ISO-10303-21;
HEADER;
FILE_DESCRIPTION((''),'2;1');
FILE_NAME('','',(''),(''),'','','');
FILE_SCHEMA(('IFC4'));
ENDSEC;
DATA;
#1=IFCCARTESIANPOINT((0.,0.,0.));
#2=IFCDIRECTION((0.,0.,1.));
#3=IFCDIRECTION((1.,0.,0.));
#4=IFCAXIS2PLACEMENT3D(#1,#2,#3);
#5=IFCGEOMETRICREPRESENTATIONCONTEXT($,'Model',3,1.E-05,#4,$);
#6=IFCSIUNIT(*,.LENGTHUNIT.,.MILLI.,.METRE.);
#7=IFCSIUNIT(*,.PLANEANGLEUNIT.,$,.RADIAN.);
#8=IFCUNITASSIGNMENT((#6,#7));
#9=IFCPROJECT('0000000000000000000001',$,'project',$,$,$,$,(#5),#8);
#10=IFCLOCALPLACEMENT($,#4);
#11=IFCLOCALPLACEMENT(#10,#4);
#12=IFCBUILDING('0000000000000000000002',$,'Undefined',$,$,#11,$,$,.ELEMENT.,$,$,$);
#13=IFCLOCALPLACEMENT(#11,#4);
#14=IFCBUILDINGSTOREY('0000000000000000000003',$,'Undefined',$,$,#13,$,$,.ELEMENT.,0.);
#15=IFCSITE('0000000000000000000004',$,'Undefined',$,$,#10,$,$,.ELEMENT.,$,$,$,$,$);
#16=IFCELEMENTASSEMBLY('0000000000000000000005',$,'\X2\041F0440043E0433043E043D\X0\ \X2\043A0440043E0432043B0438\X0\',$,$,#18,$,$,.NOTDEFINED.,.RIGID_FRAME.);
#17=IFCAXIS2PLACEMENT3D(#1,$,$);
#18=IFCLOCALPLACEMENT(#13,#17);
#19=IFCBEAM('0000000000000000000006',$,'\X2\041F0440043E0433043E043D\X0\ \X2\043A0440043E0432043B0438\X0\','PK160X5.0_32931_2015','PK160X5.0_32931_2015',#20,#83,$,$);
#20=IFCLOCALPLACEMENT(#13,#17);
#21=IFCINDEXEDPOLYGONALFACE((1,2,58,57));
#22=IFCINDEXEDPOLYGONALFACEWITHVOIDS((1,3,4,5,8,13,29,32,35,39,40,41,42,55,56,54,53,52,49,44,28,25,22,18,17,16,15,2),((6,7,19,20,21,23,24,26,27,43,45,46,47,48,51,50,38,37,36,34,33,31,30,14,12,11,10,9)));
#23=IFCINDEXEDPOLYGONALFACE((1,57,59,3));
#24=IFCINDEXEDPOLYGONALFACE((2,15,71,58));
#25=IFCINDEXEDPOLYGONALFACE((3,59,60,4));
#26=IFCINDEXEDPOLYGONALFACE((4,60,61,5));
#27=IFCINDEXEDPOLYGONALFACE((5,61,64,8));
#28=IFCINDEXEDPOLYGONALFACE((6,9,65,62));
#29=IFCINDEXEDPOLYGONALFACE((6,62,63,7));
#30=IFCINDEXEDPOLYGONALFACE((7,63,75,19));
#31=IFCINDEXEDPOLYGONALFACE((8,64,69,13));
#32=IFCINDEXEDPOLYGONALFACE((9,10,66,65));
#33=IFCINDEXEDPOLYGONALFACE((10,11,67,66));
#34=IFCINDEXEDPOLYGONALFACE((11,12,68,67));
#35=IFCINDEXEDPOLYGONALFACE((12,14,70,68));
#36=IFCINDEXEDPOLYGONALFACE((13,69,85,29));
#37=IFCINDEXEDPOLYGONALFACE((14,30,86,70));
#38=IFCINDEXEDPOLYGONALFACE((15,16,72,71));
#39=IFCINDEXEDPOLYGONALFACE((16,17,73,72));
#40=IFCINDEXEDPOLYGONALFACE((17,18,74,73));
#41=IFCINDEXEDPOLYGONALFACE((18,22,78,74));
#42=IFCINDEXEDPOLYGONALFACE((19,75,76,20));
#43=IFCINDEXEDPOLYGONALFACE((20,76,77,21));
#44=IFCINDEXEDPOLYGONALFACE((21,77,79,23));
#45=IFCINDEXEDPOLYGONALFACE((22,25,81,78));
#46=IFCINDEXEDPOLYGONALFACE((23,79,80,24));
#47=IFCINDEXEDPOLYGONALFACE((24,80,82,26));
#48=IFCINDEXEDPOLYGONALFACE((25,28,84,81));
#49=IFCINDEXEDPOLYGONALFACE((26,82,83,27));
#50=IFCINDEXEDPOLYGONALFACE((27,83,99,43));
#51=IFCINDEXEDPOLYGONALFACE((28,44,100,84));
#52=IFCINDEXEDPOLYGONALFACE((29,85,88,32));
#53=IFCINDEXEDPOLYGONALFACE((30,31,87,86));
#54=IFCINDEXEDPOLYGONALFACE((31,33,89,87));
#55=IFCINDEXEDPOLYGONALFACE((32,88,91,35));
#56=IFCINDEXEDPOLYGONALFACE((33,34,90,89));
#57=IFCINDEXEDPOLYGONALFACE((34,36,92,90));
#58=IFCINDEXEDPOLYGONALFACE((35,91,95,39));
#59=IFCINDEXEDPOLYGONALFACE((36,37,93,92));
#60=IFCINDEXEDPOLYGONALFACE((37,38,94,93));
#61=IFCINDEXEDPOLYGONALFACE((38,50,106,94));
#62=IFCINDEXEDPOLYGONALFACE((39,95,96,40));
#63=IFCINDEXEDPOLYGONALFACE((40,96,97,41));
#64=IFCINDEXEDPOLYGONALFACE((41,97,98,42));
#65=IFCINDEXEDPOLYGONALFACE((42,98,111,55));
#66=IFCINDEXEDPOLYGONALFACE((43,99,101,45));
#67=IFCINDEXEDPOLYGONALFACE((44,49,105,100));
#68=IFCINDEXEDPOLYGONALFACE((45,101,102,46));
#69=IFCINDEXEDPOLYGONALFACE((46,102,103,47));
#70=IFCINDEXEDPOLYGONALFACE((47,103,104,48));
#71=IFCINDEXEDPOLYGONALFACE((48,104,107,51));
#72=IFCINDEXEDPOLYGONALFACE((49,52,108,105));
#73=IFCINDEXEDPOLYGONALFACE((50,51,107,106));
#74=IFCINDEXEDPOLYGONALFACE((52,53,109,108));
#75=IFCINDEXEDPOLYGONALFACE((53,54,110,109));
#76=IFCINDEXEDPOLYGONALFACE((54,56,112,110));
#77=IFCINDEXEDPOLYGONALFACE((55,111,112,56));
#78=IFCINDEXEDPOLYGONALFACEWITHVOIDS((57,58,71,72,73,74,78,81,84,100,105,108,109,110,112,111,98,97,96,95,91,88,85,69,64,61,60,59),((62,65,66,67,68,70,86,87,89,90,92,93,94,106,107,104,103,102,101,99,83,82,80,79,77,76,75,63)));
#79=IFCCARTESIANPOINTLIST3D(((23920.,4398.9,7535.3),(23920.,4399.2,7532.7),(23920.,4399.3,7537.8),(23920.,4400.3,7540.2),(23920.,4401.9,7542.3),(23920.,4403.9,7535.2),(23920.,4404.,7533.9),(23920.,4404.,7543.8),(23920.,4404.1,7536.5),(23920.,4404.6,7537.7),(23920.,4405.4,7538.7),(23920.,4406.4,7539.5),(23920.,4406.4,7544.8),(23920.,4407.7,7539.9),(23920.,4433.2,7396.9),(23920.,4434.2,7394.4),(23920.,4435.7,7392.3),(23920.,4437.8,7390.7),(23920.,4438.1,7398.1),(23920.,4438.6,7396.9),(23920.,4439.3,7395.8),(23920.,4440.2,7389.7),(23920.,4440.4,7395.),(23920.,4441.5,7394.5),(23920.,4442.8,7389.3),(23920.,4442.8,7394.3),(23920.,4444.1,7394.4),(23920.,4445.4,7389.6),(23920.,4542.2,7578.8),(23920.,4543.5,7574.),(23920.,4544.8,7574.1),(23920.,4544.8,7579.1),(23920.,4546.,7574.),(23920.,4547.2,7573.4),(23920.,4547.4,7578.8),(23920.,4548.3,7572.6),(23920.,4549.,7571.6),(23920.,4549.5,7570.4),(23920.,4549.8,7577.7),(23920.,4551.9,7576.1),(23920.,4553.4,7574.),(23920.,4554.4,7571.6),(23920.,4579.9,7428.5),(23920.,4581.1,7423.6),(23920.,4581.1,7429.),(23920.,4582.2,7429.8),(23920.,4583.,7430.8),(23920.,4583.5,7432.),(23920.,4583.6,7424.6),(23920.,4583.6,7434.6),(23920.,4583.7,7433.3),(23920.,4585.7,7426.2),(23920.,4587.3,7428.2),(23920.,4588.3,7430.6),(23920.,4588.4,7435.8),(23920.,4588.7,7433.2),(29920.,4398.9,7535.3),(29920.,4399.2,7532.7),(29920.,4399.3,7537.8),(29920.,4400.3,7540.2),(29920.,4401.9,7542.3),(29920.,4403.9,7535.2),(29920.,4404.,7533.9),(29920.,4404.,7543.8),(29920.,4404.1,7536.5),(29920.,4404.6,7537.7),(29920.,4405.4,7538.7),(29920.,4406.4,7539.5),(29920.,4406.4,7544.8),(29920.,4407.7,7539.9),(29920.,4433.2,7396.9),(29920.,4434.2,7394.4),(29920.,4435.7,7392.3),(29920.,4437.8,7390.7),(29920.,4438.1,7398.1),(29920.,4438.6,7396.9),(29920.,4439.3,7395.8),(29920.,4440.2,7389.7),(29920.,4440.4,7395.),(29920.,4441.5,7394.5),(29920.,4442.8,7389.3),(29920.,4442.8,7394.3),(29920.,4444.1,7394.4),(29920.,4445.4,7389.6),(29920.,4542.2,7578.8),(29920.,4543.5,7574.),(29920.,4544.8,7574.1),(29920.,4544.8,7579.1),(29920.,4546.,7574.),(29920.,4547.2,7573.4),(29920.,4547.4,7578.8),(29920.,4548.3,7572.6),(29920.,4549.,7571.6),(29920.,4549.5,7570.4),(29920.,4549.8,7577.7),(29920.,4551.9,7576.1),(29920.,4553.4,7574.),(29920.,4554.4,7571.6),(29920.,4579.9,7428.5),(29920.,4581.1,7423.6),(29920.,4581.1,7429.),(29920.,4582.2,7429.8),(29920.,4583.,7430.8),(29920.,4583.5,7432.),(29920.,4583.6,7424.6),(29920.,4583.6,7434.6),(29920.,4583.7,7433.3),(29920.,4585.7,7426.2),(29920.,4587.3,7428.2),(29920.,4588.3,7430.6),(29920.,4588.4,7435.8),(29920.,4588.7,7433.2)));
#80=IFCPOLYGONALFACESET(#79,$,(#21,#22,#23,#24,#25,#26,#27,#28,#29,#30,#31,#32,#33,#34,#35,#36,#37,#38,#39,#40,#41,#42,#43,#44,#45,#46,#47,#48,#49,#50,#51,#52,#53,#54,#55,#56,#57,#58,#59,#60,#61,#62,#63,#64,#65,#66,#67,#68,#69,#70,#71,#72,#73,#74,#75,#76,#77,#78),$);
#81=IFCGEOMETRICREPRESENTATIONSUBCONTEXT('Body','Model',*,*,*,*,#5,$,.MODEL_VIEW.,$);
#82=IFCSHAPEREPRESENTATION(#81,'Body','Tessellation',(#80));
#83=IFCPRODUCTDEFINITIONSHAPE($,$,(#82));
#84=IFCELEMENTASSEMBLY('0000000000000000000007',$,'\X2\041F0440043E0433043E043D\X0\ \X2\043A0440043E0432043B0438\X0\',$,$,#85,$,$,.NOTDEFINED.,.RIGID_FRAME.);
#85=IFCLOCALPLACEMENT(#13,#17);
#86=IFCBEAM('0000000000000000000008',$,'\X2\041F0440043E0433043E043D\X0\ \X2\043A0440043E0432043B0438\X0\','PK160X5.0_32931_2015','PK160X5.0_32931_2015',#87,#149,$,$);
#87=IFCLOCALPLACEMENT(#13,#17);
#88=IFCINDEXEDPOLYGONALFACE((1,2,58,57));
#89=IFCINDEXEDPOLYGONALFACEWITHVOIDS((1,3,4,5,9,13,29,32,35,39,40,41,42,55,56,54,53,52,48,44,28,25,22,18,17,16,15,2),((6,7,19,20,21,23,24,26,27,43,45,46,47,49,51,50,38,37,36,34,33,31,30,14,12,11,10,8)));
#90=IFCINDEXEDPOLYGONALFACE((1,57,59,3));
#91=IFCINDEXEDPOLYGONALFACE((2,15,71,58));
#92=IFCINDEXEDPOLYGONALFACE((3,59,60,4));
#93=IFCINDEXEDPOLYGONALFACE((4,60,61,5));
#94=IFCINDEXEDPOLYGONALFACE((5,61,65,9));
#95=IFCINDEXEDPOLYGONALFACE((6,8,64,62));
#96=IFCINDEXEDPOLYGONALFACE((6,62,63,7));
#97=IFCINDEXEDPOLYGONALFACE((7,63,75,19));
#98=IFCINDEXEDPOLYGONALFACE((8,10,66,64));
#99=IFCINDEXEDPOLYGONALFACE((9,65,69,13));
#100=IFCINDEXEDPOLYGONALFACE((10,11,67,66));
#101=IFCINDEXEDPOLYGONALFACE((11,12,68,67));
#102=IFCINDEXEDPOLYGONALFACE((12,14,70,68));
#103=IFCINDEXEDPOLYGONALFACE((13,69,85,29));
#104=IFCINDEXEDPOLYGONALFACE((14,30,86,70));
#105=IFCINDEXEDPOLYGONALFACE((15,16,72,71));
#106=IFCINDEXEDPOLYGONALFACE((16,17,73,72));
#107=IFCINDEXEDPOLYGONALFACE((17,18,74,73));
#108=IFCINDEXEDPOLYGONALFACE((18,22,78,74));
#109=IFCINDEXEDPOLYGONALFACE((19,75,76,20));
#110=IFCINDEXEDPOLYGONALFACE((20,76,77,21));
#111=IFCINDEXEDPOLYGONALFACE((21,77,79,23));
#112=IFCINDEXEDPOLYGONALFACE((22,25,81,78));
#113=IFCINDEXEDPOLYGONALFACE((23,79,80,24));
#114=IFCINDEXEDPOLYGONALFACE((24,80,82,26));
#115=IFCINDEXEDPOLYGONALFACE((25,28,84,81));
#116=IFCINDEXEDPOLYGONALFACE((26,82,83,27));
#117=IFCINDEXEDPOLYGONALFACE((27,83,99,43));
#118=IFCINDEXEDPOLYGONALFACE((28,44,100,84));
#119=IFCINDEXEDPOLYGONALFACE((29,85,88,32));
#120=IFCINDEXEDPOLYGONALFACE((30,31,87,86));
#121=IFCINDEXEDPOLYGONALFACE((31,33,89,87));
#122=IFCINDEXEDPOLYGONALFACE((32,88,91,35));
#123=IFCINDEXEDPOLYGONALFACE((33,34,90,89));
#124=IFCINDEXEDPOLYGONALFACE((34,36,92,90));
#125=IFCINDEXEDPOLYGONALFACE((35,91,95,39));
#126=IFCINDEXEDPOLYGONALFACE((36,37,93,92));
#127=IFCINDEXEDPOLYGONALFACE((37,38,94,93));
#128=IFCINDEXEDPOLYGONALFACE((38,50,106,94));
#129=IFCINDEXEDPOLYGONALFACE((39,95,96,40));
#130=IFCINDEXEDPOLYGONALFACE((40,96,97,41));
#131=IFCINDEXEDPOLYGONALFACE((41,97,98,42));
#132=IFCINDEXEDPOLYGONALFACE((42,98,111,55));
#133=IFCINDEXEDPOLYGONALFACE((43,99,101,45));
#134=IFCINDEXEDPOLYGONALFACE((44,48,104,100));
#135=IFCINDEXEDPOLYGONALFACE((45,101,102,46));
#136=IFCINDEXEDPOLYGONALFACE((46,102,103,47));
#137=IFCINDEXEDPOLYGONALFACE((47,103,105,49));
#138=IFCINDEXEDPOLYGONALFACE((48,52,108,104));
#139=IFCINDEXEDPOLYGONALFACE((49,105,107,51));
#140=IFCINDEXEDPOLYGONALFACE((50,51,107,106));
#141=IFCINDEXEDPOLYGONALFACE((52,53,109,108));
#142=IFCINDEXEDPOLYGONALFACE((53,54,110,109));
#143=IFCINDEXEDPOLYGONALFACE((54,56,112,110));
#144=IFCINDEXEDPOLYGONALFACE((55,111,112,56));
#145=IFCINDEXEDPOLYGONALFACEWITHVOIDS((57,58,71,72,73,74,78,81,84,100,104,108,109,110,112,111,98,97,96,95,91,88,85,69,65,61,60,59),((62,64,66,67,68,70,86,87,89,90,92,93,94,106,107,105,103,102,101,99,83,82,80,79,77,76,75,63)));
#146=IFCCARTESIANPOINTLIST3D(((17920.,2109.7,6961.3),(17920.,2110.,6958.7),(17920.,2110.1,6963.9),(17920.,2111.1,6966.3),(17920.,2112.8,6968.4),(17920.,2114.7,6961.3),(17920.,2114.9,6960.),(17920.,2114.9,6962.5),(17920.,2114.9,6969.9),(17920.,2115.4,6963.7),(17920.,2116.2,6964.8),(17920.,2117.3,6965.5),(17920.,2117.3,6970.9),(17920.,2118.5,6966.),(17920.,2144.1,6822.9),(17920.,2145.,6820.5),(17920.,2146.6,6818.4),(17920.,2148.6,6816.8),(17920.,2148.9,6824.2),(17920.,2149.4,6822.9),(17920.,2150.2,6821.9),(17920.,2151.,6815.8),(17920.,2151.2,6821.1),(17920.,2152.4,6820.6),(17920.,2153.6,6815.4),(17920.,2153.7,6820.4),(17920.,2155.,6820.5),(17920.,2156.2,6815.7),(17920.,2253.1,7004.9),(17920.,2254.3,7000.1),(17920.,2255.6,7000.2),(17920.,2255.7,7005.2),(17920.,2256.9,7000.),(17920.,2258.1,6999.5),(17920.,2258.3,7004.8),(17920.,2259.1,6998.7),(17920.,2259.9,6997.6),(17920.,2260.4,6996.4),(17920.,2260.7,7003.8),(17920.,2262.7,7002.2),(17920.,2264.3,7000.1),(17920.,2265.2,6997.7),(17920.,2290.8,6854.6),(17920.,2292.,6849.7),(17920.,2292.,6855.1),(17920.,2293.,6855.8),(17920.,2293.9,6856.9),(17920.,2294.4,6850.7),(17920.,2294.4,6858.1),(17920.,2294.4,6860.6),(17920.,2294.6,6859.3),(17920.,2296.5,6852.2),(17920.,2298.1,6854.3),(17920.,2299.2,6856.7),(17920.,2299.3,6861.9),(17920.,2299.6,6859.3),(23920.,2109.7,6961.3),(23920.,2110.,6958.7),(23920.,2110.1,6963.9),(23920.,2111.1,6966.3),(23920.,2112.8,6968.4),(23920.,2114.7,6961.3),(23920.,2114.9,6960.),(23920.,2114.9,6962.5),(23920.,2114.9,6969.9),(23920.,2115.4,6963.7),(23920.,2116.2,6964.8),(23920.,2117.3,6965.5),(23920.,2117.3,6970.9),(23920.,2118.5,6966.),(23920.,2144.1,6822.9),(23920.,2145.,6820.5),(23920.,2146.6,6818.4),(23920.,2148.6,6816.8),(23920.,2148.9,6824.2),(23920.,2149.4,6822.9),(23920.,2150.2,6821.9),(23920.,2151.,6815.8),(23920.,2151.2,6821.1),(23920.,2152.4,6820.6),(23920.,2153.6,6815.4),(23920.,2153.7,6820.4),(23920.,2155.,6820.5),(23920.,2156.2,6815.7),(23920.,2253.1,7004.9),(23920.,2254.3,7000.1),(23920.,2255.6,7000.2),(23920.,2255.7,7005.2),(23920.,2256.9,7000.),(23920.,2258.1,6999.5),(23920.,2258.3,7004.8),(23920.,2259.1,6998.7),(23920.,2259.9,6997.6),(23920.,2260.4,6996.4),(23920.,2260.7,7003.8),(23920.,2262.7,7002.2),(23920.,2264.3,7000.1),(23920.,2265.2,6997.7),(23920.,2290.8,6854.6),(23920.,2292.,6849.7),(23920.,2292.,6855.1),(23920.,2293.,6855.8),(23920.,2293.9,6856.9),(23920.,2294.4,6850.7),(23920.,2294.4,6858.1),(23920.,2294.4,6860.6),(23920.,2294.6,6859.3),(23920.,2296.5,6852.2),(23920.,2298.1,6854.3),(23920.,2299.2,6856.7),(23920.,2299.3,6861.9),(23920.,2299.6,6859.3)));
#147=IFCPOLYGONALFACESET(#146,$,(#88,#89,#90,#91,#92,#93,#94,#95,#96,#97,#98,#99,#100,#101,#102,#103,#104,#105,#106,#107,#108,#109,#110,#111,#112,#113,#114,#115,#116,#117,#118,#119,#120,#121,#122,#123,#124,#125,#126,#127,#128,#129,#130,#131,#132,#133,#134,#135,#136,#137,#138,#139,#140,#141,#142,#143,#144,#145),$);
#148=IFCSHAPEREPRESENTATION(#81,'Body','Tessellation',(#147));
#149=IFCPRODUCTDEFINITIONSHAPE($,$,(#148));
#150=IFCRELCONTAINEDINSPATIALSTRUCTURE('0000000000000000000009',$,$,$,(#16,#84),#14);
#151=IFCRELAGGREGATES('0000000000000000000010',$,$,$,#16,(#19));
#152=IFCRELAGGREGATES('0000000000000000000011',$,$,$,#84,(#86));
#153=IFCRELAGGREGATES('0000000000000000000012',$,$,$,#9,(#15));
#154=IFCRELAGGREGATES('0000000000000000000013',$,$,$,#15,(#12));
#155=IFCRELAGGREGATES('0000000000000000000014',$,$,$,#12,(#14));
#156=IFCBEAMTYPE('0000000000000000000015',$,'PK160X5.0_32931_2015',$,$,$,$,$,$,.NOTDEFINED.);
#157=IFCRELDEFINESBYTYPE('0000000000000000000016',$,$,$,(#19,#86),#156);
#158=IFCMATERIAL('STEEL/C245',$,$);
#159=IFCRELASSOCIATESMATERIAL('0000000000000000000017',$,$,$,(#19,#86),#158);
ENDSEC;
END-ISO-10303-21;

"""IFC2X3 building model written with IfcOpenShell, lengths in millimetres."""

from ifc_helpers import new_model, si_unit, frame, origin_with_axes, origin_2d_with_axis, place, context, subcontext, project, spatial, hollow_rectangle, extrude, material, type_object, element, aggregate, save


model = new_model("IFC2X3")

# Units and contexts
model_context = context("Model", 3, precision=1e-05, world=origin_with_axes())
body_context = subcontext(model_context, "Body", "Model", "MODEL_VIEW")
ifc_project = project(units=[si_unit("LENGTHUNIT", "METRE", prefix="MILLI"), si_unit("PLANEANGLEUNIT", "RADIAN")], contexts=[model_context])

# Site, building, storey
site_placement = place(None, origin_with_axes())
site = spatial("IfcSite", under=ifc_project, at=site_placement, Name="Undefined", CompositionType="ELEMENT")
building_placement = place(site_placement, origin_with_axes())
building = spatial("IfcBuilding", under=site, at=building_placement, Name="Undefined", CompositionType="ELEMENT")
storey_placement = place(building_placement, origin_with_axes())
storey = spatial("IfcBuildingStorey", under=building, at=storey_placement, Name="Undefined", CompositionType="ELEMENT", Elevation=0.0)

# Shared definitions
ifc_material = material(Name="STEEL/C245")

# Element assemblies, beams
beam_type_1 = type_object("IfcBeamType", Name="PK160X5.0_32931_2015", PredefinedType="NOTDEFINED")
assembly_1_placement = place(storey_placement, origin_with_axes())
assembly_1 = element("IfcElementAssembly", 1, at=assembly_1_placement, inside=storey, Name="Прогон кровли", AssemblyPlace="NOTDEFINED", PredefinedType="RIGID_FRAME")
beam_1_placement = place(assembly_1_placement, frame((23920.0, 4493.8, 7484.2), z_axis=(0.0, -0.243188, 0.969979), x_axis=(1.0, 0.0, 0.0)))
beam_1 = element("IfcBeam", 2, at=beam_1_placement, type_object=beam_type_1, material=ifc_material, Name="Прогон кровли", Description="PK160X5.0_32931_2015", ObjectType="PK160X5.0_32931_2015", context=body_context, shape_type="SweptSolid", body=[
    extrude(hollow_rectangle(XDim=160.0, YDim=160.0, WallThickness=5.0, InnerFilletRadius=5.0, OuterFilletRadius=10.0, at=origin_2d_with_axis()), frame((6000.0, 0.0, 0.0), z_axis=(-1.0, 0.0, 0.0), x_axis=(0.0, -1.0, 0.0)), (0.0, 0.0, 1.0), 6000.0),
])
aggregate(assembly_1, [beam_1])
assembly_2_placement = place(storey_placement, origin_with_axes())
assembly_2 = element("IfcElementAssembly", 3, at=assembly_2_placement, inside=storey, Name="Прогон кровли", AssemblyPlace="NOTDEFINED", PredefinedType="RIGID_FRAME")
beam_2_placement = place(assembly_2_placement, frame((17920.0, 2204.6, 6910.3), z_axis=(0.0, -0.243188, 0.969979), x_axis=(1.0, 0.0, 0.0)))
beam_2 = element("IfcBeam", 4, at=beam_2_placement, type_object=beam_type_1, material=ifc_material, Name="Прогон кровли", Description="PK160X5.0_32931_2015", ObjectType="PK160X5.0_32931_2015", context=body_context, shape_type="SweptSolid", body=[
    extrude(hollow_rectangle(XDim=160.0, YDim=160.0, WallThickness=5.0, InnerFilletRadius=5.0, OuterFilletRadius=10.0, at=origin_2d_with_axis()), frame((6000.0, 0.0, 0.0), z_axis=(-1.0, 0.0, 0.0), x_axis=(0.0, -1.0, 0.0)), (0.0, 0.0, 1.0), 6000.0),
])
aggregate(assembly_2, [beam_2])

save(model, "model.ifc")
